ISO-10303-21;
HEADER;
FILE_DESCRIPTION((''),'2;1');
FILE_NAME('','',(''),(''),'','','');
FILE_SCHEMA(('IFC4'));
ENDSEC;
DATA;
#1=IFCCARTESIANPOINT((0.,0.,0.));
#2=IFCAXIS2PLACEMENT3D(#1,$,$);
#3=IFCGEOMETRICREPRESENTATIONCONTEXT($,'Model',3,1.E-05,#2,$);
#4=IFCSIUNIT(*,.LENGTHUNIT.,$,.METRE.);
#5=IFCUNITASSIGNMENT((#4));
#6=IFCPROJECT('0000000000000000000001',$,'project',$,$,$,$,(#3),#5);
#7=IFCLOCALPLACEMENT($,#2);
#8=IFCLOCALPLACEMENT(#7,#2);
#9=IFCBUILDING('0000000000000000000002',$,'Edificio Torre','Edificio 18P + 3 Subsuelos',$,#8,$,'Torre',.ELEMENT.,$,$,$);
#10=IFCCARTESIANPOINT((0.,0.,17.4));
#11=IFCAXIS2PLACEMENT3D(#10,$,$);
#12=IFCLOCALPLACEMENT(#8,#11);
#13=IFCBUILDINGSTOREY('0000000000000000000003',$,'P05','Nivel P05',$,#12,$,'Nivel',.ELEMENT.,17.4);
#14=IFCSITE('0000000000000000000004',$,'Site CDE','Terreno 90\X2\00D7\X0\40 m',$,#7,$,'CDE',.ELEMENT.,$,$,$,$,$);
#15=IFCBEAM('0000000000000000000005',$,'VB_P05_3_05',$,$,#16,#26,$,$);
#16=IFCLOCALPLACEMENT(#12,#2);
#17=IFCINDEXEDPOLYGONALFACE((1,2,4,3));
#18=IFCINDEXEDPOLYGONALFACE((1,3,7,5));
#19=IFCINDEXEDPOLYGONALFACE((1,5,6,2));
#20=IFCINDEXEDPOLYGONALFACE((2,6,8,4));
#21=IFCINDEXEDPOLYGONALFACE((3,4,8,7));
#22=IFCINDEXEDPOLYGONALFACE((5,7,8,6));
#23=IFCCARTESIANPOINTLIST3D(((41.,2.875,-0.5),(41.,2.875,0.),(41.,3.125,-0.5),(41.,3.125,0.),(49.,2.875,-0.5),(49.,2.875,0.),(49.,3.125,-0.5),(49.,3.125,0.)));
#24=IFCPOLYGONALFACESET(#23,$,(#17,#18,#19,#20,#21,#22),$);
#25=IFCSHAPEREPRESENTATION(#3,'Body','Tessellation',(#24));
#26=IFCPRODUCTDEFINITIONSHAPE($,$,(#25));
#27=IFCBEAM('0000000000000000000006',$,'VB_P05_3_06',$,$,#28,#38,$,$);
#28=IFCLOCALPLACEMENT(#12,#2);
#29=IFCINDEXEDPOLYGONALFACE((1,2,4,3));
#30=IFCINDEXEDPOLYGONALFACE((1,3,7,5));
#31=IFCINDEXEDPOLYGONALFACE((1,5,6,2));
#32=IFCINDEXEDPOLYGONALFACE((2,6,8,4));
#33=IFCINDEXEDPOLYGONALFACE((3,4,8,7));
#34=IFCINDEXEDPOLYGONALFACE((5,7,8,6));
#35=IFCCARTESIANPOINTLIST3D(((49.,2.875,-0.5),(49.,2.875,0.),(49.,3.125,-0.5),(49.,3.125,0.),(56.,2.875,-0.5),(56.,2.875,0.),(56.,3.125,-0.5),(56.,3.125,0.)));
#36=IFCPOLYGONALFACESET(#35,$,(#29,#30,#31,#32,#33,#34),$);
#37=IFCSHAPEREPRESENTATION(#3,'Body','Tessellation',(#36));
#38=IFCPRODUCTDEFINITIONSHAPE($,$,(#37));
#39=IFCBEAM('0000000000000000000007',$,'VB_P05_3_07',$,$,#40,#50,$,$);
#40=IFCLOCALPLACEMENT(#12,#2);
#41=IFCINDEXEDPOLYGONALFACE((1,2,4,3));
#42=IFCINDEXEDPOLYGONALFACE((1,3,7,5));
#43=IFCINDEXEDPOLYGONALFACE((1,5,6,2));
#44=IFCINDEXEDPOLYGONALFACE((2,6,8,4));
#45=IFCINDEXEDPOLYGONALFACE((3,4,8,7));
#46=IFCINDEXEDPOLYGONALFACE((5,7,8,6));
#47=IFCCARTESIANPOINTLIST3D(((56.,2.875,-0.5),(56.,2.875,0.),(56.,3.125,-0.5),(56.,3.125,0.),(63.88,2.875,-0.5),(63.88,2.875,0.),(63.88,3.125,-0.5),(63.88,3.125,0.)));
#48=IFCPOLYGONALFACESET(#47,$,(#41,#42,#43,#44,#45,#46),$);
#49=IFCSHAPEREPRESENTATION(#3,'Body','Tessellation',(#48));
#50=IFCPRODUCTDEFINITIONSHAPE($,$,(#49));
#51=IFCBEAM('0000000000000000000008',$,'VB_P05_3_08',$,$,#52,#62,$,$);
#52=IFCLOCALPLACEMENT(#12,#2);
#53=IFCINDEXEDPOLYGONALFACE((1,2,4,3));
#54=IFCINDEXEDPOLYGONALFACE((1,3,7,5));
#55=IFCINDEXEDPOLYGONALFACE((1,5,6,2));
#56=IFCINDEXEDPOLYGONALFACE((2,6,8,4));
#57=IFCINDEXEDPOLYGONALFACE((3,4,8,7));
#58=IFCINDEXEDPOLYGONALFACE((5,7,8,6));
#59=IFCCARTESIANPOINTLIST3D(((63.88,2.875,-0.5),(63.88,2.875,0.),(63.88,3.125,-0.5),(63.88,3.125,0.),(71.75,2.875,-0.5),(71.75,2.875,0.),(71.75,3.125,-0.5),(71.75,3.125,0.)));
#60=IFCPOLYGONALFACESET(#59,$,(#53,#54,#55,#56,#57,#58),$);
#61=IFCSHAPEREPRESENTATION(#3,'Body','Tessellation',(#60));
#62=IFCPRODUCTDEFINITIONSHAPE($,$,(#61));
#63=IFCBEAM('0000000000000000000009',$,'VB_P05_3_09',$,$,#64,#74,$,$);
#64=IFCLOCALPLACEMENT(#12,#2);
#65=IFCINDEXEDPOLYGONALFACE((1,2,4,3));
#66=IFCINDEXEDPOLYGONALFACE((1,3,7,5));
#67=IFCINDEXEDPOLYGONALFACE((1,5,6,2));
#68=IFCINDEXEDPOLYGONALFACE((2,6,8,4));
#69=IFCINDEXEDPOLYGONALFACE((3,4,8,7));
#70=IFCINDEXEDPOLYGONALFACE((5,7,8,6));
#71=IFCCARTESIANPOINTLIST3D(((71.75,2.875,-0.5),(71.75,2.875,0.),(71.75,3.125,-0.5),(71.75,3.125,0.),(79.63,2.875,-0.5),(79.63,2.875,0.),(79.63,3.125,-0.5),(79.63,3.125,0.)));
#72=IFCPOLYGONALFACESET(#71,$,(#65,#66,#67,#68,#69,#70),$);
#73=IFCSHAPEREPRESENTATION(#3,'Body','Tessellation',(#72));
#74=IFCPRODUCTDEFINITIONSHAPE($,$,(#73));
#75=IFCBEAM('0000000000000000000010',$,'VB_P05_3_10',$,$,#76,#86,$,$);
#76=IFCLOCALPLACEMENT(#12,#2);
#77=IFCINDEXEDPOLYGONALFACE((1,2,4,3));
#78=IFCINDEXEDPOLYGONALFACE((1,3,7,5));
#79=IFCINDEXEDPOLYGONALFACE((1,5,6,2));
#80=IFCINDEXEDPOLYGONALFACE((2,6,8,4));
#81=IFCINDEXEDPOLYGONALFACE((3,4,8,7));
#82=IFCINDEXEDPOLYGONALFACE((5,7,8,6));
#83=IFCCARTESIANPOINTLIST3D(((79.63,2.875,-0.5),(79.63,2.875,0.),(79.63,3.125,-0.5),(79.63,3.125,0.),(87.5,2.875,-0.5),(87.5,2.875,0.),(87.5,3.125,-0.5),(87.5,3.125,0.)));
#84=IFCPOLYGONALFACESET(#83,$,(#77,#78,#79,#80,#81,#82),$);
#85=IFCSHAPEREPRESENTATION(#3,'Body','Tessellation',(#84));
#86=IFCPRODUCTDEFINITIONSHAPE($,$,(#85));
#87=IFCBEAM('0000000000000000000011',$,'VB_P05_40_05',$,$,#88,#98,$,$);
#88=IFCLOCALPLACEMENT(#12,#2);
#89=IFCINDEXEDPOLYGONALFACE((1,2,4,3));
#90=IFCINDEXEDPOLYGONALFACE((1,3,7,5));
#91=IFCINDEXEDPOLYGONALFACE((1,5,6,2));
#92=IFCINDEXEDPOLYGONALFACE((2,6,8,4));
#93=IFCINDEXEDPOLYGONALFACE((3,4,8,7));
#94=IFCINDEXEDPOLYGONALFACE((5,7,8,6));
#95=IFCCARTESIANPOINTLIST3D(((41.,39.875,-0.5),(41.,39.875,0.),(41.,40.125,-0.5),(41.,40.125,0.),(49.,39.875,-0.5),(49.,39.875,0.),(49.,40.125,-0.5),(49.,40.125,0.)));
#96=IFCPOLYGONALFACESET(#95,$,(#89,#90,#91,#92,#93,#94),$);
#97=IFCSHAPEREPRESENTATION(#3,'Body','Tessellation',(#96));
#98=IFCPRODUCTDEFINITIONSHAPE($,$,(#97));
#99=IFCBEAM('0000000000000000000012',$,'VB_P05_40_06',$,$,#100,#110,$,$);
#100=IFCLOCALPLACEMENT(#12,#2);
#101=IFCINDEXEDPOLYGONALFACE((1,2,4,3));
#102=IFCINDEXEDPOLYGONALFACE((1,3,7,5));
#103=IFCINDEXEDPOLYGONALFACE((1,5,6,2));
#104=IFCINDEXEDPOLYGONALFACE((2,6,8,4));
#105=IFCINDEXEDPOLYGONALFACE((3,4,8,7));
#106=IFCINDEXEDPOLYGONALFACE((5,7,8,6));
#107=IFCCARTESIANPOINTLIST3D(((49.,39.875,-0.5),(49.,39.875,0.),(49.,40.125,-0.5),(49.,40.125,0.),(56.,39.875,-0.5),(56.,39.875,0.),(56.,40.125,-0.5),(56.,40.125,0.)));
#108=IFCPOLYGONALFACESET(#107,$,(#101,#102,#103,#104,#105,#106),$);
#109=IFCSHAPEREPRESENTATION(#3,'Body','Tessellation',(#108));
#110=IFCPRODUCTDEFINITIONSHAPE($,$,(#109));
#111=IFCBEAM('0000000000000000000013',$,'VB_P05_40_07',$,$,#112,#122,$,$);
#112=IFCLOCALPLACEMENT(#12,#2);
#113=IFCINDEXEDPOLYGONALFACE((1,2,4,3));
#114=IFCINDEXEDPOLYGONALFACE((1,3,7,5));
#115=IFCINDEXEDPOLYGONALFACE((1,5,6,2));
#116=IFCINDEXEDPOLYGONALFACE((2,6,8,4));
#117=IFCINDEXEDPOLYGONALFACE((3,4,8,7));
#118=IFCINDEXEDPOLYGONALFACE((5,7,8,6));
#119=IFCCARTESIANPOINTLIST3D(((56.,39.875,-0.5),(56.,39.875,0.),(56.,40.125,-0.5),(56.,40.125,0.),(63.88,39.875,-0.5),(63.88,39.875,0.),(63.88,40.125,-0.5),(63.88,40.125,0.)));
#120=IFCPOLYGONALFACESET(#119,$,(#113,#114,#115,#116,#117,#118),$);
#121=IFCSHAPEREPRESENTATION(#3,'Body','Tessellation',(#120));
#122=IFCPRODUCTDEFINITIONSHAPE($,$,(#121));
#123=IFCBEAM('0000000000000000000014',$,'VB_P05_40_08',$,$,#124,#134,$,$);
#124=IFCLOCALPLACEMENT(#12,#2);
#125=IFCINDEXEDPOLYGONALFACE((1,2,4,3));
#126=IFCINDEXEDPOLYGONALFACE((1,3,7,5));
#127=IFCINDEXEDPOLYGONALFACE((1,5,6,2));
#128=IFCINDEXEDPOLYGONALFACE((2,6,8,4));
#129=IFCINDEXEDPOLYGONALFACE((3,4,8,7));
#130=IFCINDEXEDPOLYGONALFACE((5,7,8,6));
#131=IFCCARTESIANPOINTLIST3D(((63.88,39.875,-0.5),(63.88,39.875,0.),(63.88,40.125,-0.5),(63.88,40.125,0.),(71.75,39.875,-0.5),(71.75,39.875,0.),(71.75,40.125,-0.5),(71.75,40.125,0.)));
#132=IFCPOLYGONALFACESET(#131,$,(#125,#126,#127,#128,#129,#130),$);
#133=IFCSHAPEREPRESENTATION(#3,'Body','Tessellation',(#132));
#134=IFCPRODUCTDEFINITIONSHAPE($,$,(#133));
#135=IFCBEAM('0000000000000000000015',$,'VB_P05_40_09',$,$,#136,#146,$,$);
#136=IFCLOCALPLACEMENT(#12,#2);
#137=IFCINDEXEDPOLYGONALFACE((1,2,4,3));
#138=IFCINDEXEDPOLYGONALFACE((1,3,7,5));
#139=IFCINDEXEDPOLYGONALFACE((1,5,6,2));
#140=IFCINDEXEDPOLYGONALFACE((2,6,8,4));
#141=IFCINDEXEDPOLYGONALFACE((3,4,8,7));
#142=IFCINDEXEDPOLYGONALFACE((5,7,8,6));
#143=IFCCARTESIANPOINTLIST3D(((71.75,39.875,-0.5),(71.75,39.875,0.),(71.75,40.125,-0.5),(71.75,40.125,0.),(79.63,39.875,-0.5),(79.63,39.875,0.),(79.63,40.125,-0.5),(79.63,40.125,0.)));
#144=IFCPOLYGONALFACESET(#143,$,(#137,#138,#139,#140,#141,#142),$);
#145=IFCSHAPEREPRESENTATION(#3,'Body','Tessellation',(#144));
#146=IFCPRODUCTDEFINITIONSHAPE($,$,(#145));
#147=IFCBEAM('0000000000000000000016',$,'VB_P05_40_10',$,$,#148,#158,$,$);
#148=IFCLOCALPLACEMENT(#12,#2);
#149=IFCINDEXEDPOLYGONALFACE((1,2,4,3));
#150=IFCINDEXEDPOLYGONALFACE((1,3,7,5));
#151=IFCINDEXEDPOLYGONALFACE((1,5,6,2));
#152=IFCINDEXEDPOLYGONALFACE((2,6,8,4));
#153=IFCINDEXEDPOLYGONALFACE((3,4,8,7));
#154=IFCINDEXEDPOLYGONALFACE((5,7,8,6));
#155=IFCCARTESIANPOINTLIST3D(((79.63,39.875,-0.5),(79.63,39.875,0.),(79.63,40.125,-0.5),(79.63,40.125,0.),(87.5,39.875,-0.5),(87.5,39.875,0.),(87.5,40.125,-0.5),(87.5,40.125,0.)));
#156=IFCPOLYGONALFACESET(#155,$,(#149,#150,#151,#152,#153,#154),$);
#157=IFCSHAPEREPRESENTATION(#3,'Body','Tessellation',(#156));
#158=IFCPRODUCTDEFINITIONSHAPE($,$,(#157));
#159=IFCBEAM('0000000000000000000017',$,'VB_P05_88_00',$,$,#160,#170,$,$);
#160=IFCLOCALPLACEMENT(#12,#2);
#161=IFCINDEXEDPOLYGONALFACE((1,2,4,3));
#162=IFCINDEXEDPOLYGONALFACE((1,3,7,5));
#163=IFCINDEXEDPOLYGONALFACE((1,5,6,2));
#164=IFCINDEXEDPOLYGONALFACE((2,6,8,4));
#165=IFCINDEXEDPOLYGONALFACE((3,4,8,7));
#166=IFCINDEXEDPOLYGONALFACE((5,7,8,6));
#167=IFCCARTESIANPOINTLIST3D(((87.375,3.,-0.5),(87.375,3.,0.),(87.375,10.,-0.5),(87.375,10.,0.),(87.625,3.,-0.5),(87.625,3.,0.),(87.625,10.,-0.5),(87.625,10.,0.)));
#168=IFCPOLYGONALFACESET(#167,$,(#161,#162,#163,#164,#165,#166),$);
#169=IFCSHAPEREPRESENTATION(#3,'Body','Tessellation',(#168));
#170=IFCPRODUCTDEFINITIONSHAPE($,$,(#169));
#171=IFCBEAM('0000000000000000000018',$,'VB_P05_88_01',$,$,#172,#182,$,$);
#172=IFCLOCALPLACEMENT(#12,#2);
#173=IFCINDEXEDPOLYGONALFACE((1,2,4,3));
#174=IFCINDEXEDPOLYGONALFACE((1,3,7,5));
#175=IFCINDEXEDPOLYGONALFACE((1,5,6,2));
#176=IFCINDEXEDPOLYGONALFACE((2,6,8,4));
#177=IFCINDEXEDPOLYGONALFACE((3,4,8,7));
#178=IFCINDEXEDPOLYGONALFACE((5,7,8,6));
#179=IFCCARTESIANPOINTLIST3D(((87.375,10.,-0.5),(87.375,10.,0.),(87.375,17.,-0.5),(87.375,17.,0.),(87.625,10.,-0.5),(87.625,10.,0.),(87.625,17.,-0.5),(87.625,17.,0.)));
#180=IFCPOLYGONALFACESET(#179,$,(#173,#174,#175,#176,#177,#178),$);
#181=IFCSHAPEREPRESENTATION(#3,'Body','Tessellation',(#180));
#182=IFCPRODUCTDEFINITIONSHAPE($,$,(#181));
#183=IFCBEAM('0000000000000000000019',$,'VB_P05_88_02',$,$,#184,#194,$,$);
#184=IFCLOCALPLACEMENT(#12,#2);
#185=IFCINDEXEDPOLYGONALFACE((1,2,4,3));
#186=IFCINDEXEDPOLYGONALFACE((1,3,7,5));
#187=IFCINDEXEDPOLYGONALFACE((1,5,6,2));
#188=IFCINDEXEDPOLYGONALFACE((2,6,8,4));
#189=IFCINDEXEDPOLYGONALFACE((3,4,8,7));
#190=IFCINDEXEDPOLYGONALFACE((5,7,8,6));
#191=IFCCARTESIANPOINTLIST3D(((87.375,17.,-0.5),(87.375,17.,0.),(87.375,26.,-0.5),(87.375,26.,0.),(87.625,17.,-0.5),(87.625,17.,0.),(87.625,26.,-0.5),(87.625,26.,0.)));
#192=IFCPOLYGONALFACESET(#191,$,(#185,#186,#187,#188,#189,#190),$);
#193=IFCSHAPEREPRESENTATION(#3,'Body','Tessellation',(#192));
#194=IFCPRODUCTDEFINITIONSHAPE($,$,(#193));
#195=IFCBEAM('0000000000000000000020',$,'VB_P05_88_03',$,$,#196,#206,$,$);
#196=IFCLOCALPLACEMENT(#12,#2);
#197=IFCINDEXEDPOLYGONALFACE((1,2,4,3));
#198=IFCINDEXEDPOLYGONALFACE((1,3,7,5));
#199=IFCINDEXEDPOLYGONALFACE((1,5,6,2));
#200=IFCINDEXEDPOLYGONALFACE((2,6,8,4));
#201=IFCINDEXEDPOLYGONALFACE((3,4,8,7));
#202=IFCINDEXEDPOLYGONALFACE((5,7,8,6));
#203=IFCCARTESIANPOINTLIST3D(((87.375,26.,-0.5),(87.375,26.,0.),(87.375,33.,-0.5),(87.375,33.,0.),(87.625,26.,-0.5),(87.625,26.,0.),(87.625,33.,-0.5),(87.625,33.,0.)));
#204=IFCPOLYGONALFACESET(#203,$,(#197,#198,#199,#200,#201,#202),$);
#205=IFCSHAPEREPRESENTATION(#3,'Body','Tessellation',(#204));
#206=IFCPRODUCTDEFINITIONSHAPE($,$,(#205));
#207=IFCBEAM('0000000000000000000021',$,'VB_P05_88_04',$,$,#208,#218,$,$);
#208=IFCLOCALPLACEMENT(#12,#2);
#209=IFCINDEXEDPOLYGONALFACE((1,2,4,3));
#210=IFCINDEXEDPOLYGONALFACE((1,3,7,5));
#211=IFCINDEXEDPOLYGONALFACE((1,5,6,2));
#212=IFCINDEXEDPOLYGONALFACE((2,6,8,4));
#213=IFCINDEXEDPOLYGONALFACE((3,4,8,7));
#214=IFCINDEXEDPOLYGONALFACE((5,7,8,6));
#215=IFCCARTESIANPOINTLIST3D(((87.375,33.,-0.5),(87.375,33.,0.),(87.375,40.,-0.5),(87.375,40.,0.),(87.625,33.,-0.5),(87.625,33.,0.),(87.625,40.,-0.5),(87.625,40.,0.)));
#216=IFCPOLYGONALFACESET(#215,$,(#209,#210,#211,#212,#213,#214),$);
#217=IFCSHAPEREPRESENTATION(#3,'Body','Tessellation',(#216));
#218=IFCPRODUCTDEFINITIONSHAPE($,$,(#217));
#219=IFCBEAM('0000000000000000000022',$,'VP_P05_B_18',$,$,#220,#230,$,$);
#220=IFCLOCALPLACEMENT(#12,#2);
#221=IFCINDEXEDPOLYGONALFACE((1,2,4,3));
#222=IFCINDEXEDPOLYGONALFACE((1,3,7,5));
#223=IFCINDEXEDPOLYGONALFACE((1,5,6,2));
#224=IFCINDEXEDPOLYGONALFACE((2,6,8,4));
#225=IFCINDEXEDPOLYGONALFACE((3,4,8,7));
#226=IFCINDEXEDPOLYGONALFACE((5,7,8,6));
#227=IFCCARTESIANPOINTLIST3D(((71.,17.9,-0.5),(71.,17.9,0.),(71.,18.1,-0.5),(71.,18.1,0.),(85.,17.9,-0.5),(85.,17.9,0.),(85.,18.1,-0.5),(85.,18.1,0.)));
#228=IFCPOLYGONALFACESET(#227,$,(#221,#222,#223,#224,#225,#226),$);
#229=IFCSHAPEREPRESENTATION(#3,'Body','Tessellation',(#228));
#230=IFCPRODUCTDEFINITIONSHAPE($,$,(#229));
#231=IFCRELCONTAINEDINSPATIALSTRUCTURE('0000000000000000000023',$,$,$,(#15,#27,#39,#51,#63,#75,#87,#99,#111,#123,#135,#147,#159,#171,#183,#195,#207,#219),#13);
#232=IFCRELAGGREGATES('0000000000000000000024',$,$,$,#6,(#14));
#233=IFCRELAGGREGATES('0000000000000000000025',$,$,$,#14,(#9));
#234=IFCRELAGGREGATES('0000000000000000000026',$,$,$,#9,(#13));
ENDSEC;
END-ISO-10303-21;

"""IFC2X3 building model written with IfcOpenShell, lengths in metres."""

from ifc_helpers import new_model, si_unit, frame, origin, origin_2d, place, context, project, spatial, rectangle, extrude, element, save


model = new_model("IFC2X3")

# Units and contexts
model_context = context("Model", 3, precision=1e-05, world=origin())
ifc_project = project(units=[si_unit("LENGTHUNIT", "METRE")], contexts=[model_context])

# Site, building, storey
site_placement = place(None, origin())
site = spatial("IfcSite", under=ifc_project, at=site_placement, Name="Site CDE", Description="Terreno 90×40 m", LongName="CDE", CompositionType="ELEMENT")
building_placement = place(site_placement, origin())
building = spatial("IfcBuilding", under=site, at=building_placement, Name="Edificio Torre", Description="Edificio 18P + 3 Subsuelos", LongName="Torre", CompositionType="ELEMENT")
storey_placement = place(building_placement, frame((0.0, 0.0, 17.4)))
storey = spatial("IfcBuildingStorey", under=building, at=storey_placement, Name="P05", Description="Nivel P05", LongName="Nivel", CompositionType="ELEMENT", Elevation=17.4)

# Beams
beam_1_placement = place(storey_placement, frame((45.0, 3.0, -0.5)))
element("IfcBeam", 1, at=beam_1_placement, inside=storey, Name="VB_P05_3_05", context=model_context, shape_type="SweptSolid", body=[
    extrude(rectangle(XDim=8.0, YDim=0.25, at=origin_2d()), origin(), (0.0, 0.0, 1.0), 0.5),
])
beam_2_placement = place(storey_placement, frame((52.5, 3.0, -0.5)))
element("IfcBeam", 2, at=beam_2_placement, inside=storey, Name="VB_P05_3_06", context=model_context, shape_type="SweptSolid", body=[
    extrude(rectangle(XDim=7.0, YDim=0.25, at=origin_2d()), origin(), (0.0, 0.0, 1.0), 0.5),
])
beam_3_placement = place(storey_placement, frame((59.94, 3.0, -0.5)))
element("IfcBeam", 3, at=beam_3_placement, inside=storey, Name="VB_P05_3_07", context=model_context, shape_type="SweptSolid", body=[
    extrude(rectangle(XDim=7.88, YDim=0.25, at=origin_2d()), origin(), (0.0, 0.0, 1.0), 0.5),
])
beam_4_placement = place(storey_placement, frame((67.815, 3.0, -0.5)))
element("IfcBeam", 4, at=beam_4_placement, inside=storey, Name="VB_P05_3_08", context=model_context, shape_type="SweptSolid", body=[
    extrude(rectangle(XDim=7.87, YDim=0.25, at=origin_2d()), origin(), (0.0, 0.0, 1.0), 0.5),
])
beam_5_placement = place(storey_placement, frame((75.69, 3.0, -0.5)))
element("IfcBeam", 5, at=beam_5_placement, inside=storey, Name="VB_P05_3_09", context=model_context, shape_type="SweptSolid", body=[
    extrude(rectangle(XDim=7.88, YDim=0.25, at=origin_2d()), origin(), (0.0, 0.0, 1.0), 0.5),
])
beam_6_placement = place(storey_placement, frame((83.565, 3.0, -0.5)))
element("IfcBeam", 6, at=beam_6_placement, inside=storey, Name="VB_P05_3_10", context=model_context, shape_type="SweptSolid", body=[
    extrude(rectangle(XDim=7.87, YDim=0.25, at=origin_2d()), origin(), (0.0, 0.0, 1.0), 0.5),
])
beam_7_placement = place(storey_placement, frame((45.0, 40.0, -0.5)))
element("IfcBeam", 7, at=beam_7_placement, inside=storey, Name="VB_P05_40_05", context=model_context, shape_type="SweptSolid", body=[
    extrude(rectangle(XDim=8.0, YDim=0.25, at=origin_2d()), origin(), (0.0, 0.0, 1.0), 0.5),
])
beam_8_placement = place(storey_placement, frame((52.5, 40.0, -0.5)))
element("IfcBeam", 8, at=beam_8_placement, inside=storey, Name="VB_P05_40_06", context=model_context, shape_type="SweptSolid", body=[
    extrude(rectangle(XDim=7.0, YDim=0.25, at=origin_2d()), origin(), (0.0, 0.0, 1.0), 0.5),
])
beam_9_placement = place(storey_placement, frame((59.94, 40.0, -0.5)))
element("IfcBeam", 9, at=beam_9_placement, inside=storey, Name="VB_P05_40_07", context=model_context, shape_type="SweptSolid", body=[
    extrude(rectangle(XDim=7.88, YDim=0.25, at=origin_2d()), origin(), (0.0, 0.0, 1.0), 0.5),
])
beam_10_placement = place(storey_placement, frame((67.815, 40.0, -0.5)))
element("IfcBeam", 10, at=beam_10_placement, inside=storey, Name="VB_P05_40_08", context=model_context, shape_type="SweptSolid", body=[
    extrude(rectangle(XDim=7.87, YDim=0.25, at=origin_2d()), origin(), (0.0, 0.0, 1.0), 0.5),
])
beam_11_placement = place(storey_placement, frame((75.69, 40.0, -0.5)))
element("IfcBeam", 11, at=beam_11_placement, inside=storey, Name="VB_P05_40_09", context=model_context, shape_type="SweptSolid", body=[
    extrude(rectangle(XDim=7.88, YDim=0.25, at=origin_2d()), origin(), (0.0, 0.0, 1.0), 0.5),
])
beam_12_placement = place(storey_placement, frame((83.565, 40.0, -0.5)))
element("IfcBeam", 12, at=beam_12_placement, inside=storey, Name="VB_P05_40_10", context=model_context, shape_type="SweptSolid", body=[
    extrude(rectangle(XDim=7.87, YDim=0.25, at=origin_2d()), origin(), (0.0, 0.0, 1.0), 0.5),
])
for number, where, name in (
    (13, (87.5, 6.5, -0.5), "VB_P05_88_00"),
    (14, (87.5, 13.5, -0.5), "VB_P05_88_01"),
):
    element("IfcBeam", number, at=place(storey_placement, frame(where)), inside=storey, Name=name, context=model_context, shape_type="SweptSolid", body=[
        extrude(rectangle(XDim=0.25, YDim=7.0, at=origin_2d()), origin(), (0.0, 0.0, 1.0), 0.5),
    ])
beam_13_placement = place(storey_placement, frame((87.5, 21.5, -0.5)))
element("IfcBeam", 15, at=beam_13_placement, inside=storey, Name="VB_P05_88_02", context=model_context, shape_type="SweptSolid", body=[
    extrude(rectangle(XDim=0.25, YDim=9.0, at=origin_2d()), origin(), (0.0, 0.0, 1.0), 0.5),
])
for number, where, name in (
    (16, (87.5, 29.5, -0.5), "VB_P05_88_03"),
    (17, (87.5, 36.5, -0.5), "VB_P05_88_04"),
):
    element("IfcBeam", number, at=place(storey_placement, frame(where)), inside=storey, Name=name, context=model_context, shape_type="SweptSolid", body=[
        extrude(rectangle(XDim=0.25, YDim=7.0, at=origin_2d()), origin(), (0.0, 0.0, 1.0), 0.5),
    ])
for number, where, name in (
    (18, (78.0, 18.0, -0.5), "VP_P05_B_18"),
):
    element("IfcBeam", number, at=place(storey_placement, frame(where)), inside=storey, Name=name, context=model_context, shape_type="SweptSolid", body=[
        extrude(rectangle(XDim=14.0, YDim=0.2, at=origin_2d()), origin(), (0.0, 0.0, 1.0), 0.5),
    ])

save(model, "model.ifc")
